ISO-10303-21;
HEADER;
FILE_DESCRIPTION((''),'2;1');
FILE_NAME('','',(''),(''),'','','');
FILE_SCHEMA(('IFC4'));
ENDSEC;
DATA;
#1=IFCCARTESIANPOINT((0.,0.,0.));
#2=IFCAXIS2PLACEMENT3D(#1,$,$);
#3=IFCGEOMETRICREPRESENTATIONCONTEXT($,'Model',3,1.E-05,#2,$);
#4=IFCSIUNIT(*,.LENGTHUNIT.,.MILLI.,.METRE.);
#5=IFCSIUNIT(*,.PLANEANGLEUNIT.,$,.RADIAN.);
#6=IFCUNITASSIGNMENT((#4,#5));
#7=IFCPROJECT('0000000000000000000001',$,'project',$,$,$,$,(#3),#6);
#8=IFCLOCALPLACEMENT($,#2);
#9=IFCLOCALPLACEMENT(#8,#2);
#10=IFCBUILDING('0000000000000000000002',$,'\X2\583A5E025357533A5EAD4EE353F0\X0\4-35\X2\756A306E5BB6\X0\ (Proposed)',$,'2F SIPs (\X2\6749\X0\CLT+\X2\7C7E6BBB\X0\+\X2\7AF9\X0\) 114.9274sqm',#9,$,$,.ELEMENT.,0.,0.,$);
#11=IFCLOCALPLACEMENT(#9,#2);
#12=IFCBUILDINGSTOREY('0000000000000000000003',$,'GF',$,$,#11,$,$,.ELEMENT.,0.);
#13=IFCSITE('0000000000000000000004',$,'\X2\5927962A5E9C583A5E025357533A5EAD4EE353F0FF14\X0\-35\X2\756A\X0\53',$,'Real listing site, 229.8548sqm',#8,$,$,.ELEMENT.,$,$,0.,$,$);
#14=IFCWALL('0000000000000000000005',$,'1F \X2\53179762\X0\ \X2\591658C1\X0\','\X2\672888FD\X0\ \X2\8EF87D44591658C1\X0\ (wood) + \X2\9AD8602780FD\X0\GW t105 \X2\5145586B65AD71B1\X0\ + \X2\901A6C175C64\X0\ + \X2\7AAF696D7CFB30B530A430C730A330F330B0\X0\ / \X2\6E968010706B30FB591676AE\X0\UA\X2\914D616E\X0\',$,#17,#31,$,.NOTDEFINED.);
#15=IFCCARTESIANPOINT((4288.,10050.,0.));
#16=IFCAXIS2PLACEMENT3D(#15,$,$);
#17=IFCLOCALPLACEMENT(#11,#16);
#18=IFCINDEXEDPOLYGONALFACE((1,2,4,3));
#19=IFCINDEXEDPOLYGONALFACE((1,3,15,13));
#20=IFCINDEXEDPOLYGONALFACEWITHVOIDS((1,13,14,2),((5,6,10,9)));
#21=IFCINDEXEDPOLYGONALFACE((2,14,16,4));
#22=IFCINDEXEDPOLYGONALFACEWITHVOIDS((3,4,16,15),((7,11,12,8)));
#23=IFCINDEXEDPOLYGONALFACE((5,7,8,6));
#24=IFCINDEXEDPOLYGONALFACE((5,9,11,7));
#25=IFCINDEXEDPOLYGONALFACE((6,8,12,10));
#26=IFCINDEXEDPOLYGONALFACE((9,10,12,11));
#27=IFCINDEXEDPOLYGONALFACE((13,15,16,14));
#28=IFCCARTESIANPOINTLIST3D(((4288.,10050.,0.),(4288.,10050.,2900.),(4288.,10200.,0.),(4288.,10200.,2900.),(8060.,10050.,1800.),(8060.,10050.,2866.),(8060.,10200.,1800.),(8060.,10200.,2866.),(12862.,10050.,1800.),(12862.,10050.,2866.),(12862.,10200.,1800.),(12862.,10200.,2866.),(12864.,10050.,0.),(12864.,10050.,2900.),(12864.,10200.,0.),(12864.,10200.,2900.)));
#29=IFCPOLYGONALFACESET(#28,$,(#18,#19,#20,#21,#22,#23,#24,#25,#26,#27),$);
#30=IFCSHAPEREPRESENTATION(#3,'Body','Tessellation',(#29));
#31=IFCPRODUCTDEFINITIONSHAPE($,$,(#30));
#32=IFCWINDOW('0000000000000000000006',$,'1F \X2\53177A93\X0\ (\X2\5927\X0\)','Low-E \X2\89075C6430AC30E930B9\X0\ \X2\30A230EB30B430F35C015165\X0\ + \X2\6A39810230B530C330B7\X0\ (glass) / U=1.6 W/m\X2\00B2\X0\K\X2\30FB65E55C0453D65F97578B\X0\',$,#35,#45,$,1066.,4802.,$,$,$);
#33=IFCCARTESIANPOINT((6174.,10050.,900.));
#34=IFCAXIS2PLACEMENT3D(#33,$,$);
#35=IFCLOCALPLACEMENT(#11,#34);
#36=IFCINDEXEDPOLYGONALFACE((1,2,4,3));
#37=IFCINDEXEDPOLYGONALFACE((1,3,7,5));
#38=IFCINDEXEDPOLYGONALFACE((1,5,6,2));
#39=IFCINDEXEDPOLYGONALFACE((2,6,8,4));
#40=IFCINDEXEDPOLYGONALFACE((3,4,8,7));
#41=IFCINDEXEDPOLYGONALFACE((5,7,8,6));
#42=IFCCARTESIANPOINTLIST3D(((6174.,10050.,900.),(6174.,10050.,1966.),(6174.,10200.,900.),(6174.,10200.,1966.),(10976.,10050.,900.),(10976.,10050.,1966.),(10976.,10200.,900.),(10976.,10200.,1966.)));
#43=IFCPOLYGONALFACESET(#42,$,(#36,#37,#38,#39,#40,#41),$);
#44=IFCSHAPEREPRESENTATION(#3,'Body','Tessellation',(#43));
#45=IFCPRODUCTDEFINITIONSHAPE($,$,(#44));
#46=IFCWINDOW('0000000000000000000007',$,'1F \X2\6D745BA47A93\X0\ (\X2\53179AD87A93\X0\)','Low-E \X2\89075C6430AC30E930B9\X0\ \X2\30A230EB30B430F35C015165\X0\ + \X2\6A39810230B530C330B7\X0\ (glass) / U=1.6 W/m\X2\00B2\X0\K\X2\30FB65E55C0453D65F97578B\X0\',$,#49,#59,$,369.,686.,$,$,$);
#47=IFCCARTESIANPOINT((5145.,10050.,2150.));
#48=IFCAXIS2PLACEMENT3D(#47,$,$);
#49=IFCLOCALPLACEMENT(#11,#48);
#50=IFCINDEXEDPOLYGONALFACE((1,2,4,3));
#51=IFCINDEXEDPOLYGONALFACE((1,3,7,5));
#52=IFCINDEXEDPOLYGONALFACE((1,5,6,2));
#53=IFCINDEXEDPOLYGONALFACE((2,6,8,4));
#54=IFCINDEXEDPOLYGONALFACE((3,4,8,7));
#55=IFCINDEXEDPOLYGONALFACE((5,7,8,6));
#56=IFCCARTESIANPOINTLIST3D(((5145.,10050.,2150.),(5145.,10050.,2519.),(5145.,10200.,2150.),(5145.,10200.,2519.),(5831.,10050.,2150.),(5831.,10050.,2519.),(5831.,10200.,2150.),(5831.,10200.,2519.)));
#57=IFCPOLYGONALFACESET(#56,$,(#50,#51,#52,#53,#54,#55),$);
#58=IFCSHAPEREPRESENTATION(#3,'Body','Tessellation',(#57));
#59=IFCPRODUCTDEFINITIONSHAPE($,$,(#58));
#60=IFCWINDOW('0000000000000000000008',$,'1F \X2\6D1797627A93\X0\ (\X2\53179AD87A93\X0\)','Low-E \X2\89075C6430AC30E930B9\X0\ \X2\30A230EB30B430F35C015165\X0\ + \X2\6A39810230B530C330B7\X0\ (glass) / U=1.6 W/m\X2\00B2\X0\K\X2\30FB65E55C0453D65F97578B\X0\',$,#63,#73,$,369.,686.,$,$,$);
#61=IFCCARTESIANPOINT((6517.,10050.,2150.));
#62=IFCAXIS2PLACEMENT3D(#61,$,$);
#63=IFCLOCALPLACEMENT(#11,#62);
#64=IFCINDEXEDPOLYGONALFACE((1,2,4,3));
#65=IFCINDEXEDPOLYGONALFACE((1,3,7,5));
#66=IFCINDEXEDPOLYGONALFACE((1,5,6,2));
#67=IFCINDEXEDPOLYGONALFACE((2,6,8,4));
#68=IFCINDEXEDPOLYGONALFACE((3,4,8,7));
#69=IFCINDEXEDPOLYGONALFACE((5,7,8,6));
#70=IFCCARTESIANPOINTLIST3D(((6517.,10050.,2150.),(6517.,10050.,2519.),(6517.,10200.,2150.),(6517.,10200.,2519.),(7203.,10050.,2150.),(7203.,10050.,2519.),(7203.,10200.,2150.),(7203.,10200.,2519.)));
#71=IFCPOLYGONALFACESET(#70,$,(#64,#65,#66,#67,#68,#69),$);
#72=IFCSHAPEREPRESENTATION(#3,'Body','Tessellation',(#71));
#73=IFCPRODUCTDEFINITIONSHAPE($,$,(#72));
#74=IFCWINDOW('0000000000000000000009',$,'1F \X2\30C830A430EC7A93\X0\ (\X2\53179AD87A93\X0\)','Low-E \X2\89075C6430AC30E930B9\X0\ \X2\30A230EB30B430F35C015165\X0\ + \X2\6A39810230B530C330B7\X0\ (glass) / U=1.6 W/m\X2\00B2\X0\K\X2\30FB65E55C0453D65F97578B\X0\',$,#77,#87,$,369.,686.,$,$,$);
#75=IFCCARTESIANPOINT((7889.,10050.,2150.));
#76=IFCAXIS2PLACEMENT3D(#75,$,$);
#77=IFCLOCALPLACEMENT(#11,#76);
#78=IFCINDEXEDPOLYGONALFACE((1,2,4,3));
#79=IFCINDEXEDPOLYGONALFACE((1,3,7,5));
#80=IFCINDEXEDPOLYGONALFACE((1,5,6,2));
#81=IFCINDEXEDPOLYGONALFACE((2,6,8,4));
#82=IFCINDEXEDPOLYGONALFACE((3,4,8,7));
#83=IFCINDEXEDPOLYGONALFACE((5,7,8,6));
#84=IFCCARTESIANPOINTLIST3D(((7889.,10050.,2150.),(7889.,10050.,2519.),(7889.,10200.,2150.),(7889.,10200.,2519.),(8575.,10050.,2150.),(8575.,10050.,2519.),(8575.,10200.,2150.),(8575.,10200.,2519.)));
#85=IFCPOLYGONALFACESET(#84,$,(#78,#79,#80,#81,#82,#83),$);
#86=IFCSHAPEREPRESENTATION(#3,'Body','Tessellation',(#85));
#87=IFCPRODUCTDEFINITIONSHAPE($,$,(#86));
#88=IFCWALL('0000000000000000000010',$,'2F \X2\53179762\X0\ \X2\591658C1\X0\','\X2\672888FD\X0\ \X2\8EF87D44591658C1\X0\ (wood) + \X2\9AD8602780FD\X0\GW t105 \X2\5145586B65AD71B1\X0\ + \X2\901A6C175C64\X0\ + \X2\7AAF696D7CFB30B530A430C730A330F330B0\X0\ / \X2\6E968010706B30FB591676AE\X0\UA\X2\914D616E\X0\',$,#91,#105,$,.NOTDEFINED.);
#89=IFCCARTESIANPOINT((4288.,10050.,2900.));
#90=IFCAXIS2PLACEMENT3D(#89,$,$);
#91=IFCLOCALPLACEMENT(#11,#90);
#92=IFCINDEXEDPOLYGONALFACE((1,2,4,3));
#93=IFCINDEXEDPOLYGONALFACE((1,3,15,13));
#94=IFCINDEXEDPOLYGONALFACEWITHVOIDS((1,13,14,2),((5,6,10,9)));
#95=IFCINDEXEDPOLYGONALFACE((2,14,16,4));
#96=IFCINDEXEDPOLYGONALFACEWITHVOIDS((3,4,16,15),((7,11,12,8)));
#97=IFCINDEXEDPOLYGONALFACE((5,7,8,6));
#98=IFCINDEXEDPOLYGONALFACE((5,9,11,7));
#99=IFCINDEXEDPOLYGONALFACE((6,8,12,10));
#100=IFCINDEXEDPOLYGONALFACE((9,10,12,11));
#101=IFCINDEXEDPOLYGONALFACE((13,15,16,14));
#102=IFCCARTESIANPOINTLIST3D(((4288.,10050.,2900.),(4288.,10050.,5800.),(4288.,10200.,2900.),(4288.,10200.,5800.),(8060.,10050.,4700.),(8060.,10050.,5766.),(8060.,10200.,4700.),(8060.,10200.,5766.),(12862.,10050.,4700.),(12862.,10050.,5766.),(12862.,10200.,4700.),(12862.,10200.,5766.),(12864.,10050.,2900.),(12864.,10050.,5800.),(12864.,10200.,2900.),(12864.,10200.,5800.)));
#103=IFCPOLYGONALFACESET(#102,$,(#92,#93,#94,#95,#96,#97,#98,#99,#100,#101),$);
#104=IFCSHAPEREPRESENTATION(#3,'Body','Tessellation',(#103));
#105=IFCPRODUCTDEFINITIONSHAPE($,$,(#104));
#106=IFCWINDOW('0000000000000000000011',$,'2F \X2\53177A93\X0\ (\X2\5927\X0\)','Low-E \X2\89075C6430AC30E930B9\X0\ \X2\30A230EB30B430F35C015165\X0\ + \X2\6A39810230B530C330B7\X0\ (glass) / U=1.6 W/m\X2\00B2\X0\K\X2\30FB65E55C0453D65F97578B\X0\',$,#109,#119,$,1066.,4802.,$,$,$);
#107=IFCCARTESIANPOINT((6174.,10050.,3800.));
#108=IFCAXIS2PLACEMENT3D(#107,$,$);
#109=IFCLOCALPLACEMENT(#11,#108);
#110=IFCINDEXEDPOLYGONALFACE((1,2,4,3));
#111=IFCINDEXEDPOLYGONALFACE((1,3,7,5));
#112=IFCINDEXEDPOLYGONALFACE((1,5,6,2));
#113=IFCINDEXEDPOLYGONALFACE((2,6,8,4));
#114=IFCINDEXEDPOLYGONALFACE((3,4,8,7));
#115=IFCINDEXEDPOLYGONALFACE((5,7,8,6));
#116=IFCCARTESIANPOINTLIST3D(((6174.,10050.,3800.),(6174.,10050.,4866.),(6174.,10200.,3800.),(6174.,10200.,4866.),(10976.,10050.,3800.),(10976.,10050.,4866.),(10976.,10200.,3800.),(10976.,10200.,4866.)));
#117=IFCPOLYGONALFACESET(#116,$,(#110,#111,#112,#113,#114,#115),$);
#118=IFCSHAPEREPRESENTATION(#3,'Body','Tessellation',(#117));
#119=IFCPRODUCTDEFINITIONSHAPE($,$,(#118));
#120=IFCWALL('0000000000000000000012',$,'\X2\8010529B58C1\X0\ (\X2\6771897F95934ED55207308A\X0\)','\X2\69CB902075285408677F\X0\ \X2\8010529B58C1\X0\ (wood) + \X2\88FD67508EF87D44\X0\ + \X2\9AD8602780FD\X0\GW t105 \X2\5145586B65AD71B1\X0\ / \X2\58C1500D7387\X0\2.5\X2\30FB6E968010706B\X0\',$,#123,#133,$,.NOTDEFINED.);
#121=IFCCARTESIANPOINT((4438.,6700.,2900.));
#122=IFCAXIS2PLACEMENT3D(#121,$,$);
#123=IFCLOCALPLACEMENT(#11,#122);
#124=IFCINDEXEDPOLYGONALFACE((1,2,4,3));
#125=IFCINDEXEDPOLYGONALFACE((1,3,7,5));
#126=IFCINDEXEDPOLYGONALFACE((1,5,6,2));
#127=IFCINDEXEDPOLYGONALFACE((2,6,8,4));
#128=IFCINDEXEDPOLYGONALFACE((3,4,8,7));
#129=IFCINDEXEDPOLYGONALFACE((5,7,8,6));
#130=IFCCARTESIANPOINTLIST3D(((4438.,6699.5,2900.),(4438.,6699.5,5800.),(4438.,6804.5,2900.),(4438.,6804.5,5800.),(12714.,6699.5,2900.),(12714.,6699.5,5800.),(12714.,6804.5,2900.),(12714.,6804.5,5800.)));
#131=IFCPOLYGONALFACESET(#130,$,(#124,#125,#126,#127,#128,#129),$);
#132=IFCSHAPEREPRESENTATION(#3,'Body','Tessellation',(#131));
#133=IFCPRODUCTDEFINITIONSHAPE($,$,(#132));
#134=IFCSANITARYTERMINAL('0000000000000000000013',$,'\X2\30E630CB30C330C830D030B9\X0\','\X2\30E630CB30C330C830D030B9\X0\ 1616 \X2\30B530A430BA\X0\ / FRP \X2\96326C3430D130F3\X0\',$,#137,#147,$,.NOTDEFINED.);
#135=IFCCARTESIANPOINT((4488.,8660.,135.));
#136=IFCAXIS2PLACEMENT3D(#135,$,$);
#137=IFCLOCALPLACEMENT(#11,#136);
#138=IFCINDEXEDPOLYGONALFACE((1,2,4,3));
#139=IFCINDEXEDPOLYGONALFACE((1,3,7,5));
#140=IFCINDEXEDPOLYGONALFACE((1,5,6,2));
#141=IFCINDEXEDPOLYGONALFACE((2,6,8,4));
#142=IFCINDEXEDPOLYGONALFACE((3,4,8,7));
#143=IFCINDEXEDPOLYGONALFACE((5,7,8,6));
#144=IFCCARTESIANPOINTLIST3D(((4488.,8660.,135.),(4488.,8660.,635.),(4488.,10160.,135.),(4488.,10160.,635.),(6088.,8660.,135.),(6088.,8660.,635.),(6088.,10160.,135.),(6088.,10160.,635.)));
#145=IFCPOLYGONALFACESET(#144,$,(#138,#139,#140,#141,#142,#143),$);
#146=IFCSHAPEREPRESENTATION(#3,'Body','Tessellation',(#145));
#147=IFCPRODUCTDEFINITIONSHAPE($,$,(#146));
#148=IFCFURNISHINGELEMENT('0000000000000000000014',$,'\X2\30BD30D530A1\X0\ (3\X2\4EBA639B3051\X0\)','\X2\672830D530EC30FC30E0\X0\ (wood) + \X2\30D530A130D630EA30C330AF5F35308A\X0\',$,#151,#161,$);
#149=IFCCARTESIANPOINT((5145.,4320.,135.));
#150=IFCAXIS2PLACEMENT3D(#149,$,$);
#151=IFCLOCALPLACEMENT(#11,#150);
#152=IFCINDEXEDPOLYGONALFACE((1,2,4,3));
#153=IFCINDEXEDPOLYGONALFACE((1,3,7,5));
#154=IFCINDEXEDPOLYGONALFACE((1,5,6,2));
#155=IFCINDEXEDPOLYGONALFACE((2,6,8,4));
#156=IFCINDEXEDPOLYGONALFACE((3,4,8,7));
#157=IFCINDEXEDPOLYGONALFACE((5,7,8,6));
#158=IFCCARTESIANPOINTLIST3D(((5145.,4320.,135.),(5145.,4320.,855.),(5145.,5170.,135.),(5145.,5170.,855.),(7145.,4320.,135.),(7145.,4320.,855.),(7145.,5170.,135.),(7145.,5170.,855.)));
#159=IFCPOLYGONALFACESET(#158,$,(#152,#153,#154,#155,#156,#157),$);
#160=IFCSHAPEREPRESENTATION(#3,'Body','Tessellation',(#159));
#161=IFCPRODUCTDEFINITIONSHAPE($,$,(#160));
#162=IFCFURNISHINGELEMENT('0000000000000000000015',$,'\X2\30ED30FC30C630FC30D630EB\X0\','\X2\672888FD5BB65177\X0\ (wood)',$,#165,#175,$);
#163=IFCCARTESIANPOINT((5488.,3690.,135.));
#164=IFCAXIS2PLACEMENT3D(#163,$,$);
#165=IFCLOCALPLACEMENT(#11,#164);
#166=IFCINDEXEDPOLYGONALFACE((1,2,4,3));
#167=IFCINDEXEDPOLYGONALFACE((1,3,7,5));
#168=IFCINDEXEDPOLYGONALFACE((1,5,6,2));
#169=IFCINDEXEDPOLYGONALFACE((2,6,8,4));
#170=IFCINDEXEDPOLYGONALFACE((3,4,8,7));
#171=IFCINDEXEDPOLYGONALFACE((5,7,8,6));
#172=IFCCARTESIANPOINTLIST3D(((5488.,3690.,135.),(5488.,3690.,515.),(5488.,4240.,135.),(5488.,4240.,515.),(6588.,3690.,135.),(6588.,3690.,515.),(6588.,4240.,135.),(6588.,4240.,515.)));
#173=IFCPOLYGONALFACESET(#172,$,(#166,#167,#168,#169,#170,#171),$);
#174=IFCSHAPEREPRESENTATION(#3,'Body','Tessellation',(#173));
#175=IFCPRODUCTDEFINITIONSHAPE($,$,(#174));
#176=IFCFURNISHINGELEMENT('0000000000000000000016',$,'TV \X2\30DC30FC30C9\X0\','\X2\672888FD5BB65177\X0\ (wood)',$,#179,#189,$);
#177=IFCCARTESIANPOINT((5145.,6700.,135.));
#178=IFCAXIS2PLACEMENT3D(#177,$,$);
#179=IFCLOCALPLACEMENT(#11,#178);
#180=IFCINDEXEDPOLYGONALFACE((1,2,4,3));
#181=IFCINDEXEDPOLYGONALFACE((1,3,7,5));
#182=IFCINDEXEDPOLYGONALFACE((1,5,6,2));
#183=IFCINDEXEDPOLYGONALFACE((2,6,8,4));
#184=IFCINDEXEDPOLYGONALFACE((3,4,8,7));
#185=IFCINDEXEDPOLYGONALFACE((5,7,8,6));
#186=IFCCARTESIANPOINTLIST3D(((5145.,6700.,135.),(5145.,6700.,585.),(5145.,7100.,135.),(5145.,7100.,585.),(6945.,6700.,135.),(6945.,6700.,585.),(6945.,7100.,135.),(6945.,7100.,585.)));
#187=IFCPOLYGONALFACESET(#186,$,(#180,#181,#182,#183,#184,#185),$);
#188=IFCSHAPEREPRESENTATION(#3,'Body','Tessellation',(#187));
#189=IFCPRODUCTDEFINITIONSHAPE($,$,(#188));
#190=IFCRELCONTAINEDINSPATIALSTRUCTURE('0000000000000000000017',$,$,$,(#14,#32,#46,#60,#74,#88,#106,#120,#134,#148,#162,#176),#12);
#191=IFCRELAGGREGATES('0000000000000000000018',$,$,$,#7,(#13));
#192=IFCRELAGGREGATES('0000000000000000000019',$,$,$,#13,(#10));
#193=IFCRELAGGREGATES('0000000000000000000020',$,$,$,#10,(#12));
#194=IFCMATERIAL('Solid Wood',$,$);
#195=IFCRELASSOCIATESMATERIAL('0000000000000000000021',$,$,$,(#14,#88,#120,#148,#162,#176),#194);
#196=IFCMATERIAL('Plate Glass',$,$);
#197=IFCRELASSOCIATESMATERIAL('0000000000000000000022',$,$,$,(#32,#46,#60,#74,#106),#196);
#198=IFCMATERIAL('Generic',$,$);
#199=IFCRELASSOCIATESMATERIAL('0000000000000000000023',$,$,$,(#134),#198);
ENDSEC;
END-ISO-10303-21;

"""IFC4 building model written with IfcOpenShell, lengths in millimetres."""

from ifc_helpers import new_model, si_unit, frame, frame_2d, origin, place, context, project, spatial, rectangle, extrude, material, element, fill, save


model = new_model("IFC4")

# Units and contexts
model_context = context("Model", 3, precision=1e-05, world=origin())
ifc_project = project(units=[si_unit("LENGTHUNIT", "METRE", prefix="MILLI"), si_unit("PLANEANGLEUNIT", "RADIAN")], contexts=[model_context])

# Site, building, storey
site_placement = place(None, origin())
site = spatial("IfcSite", under=ifc_project, at=site_placement, Name="大阪府堺市南区庭代台４-35番53", ObjectType="Real listing site, 229.8548sqm", CompositionType="ELEMENT", RefElevation=0.0)
building_placement = place(site_placement, origin())
building = spatial("IfcBuilding", under=site, at=building_placement, Name="堺市南区庭代台4-35番の家 (Proposed)", ObjectType="2F SIPs (杉CLT+籾殻+竹) 114.9274sqm", CompositionType="ELEMENT", ElevationOfRefHeight=0.0, ElevationOfTerrain=0.0)
storey_placement = place(building_placement, origin())
storey = spatial("IfcBuildingStorey", under=building, at=storey_placement, Name="GF", CompositionType="ELEMENT", Elevation=0.0)

# Wall, openings, windows
ifc_material_1 = material(Name="Solid Wood")
wall_1_placement = place(storey_placement, frame((4288.0, 10050.0, 0.0)))
wall_1 = element("IfcWall", 1, at=wall_1_placement, inside=storey, material=ifc_material_1, Name="1F 北面 外壁", Description="木製 軸組外壁 (wood) + 高性能GW t105 充填断熱 + 通気層 + 窯業系サイディング / 準耐火・外皮UA配慮", PredefinedType="NOTDEFINED", context=model_context, shape_type="SweptSolid", body=[
    extrude(rectangle(XDim=8576.0, YDim=150.0, at=frame_2d((4288.0, 75.0))), frame((4288.0, 10050.0, 0.0)), (0.0, 0.0, 1.0), 2900.0),
])
opening_1_placement = place(storey_placement, frame((6174.0, 10050.0, 900.0)))
opening_1 = element("IfcOpeningElement", 2, at=opening_1_placement, cuts=wall_1, PredefinedType="NOTDEFINED", context=model_context, shape_type="SweptSolid", body=[
    extrude(rectangle(XDim=4802.0, YDim=150.0, at=frame_2d((2401.0, 75.0))), frame((6174.0, 10050.0, 900.0)), (0.0, 0.0, 1.0), 1066.0),
])
opening_2_placement = place(storey_placement, frame((5145.0, 10050.0, 2150.0)))
opening_2 = element("IfcOpeningElement", 3, at=opening_2_placement, cuts=wall_1, PredefinedType="NOTDEFINED", context=model_context, shape_type="SweptSolid", body=[
    extrude(rectangle(XDim=686.0, YDim=150.0, at=frame_2d((343.0, 75.0))), frame((5145.0, 10050.0, 2150.0)), (0.0, 0.0, 1.0), 369.0),
])
opening_3_placement = place(storey_placement, frame((6517.0, 10050.0, 2150.0)))
opening_3 = element("IfcOpeningElement", 4, at=opening_3_placement, cuts=wall_1, PredefinedType="NOTDEFINED", context=model_context, shape_type="SweptSolid", body=[
    extrude(rectangle(XDim=686.0, YDim=150.0, at=frame_2d((343.0, 75.0))), frame((6517.0, 10050.0, 2150.0)), (0.0, 0.0, 1.0), 369.0),
])
opening_4_placement = place(storey_placement, frame((7889.0, 10050.0, 2150.0)))
opening_4 = element("IfcOpeningElement", 5, at=opening_4_placement, cuts=wall_1, PredefinedType="NOTDEFINED", context=model_context, shape_type="SweptSolid", body=[
    extrude(rectangle(XDim=686.0, YDim=150.0, at=frame_2d((343.0, 75.0))), frame((7889.0, 10050.0, 2150.0)), (0.0, 0.0, 1.0), 369.0),
])
ifc_material_2 = material(Name="Plate Glass")
window_1_placement = place(storey_placement, frame((6174.0, 10050.0, 900.0)))
window_1 = element("IfcWindow", 6, at=window_1_placement, inside=storey, material=ifc_material_2, Name="1F 北窓 (大)", Description="Low-E 複層ガラス アルゴン封入 + 樹脂サッシ (glass) / U=1.6 W/m²K・日射取得型", OverallHeight=1066.0, OverallWidth=4802.0, context=model_context, shape_type="SweptSolid", body=[
    extrude(rectangle(XDim=4802.0, YDim=150.0, at=frame_2d((2401.0, 75.0))), frame((6174.0, 10050.0, 900.0)), (0.0, 0.0, 1.0), 1066.0),
])
fill(opening_1, window_1)
window_2_placement = place(storey_placement, frame((5145.0, 10050.0, 2150.0)))
window_2 = element("IfcWindow", 7, at=window_2_placement, inside=storey, material=ifc_material_2, Name="1F 浴室窓 (北高窓)", Description="Low-E 複層ガラス アルゴン封入 + 樹脂サッシ (glass) / U=1.6 W/m²K・日射取得型", OverallHeight=369.0, OverallWidth=686.0, context=model_context, shape_type="SweptSolid", body=[
    extrude(rectangle(XDim=686.0, YDim=150.0, at=frame_2d((343.0, 75.0))), frame((5145.0, 10050.0, 2150.0)), (0.0, 0.0, 1.0), 369.0),
])
fill(opening_2, window_2)
window_3_placement = place(storey_placement, frame((6517.0, 10050.0, 2150.0)))
window_3 = element("IfcWindow", 8, at=window_3_placement, inside=storey, material=ifc_material_2, Name="1F 洗面窓 (北高窓)", Description="Low-E 複層ガラス アルゴン封入 + 樹脂サッシ (glass) / U=1.6 W/m²K・日射取得型", OverallHeight=369.0, OverallWidth=686.0, context=model_context, shape_type="SweptSolid", body=[
    extrude(rectangle(XDim=686.0, YDim=150.0, at=frame_2d((343.0, 75.0))), frame((6517.0, 10050.0, 2150.0)), (0.0, 0.0, 1.0), 369.0),
])
fill(opening_3, window_3)
window_4_placement = place(storey_placement, frame((7889.0, 10050.0, 2150.0)))
window_4 = element("IfcWindow", 9, at=window_4_placement, inside=storey, material=ifc_material_2, Name="1F トイレ窓 (北高窓)", Description="Low-E 複層ガラス アルゴン封入 + 樹脂サッシ (glass) / U=1.6 W/m²K・日射取得型", OverallHeight=369.0, OverallWidth=686.0, context=model_context, shape_type="SweptSolid", body=[
    extrude(rectangle(XDim=686.0, YDim=150.0, at=frame_2d((343.0, 75.0))), frame((7889.0, 10050.0, 2150.0)), (0.0, 0.0, 1.0), 369.0),
])
fill(opening_4, window_4)

# Wall, opening, window
wall_2_placement = place(storey_placement, frame((4288.0, 10050.0, 2900.0)))
wall_2 = element("IfcWall", 10, at=wall_2_placement, inside=storey, material=ifc_material_1, Name="2F 北面 外壁", Description="木製 軸組外壁 (wood) + 高性能GW t105 充填断熱 + 通気層 + 窯業系サイディング / 準耐火・外皮UA配慮", PredefinedType="NOTDEFINED", context=model_context, shape_type="SweptSolid", body=[
    extrude(rectangle(XDim=8576.0, YDim=150.0, at=frame_2d((4288.0, 75.0))), frame((4288.0, 10050.0, 2900.0)), (0.0, 0.0, 1.0), 2900.0),
])
opening_5_placement = place(storey_placement, frame((6174.0, 10050.0, 3800.0)))
opening_5 = element("IfcOpeningElement", 11, at=opening_5_placement, cuts=wall_2, PredefinedType="NOTDEFINED", context=model_context, shape_type="SweptSolid", body=[
    extrude(rectangle(XDim=4802.0, YDim=150.0, at=frame_2d((2401.0, 75.0))), frame((6174.0, 10050.0, 3800.0)), (0.0, 0.0, 1.0), 1066.0),
])
window_5_placement = place(storey_placement, frame((6174.0, 10050.0, 3800.0)))
window_5 = element("IfcWindow", 12, at=window_5_placement, inside=storey, material=ifc_material_2, Name="2F 北窓 (大)", Description="Low-E 複層ガラス アルゴン封入 + 樹脂サッシ (glass) / U=1.6 W/m²K・日射取得型", OverallHeight=1066.0, OverallWidth=4802.0, context=model_context, shape_type="SweptSolid", body=[
    extrude(rectangle(XDim=4802.0, YDim=150.0, at=frame_2d((2401.0, 75.0))), frame((6174.0, 10050.0, 3800.0)), (0.0, 0.0, 1.0), 1066.0),
])
fill(opening_5, window_5)

# Wall
wall_3_placement = place(storey_placement, frame((4438.0, 6700.0, 2900.0)))
element("IfcWall", 13, at=wall_3_placement, inside=storey, material=ifc_material_1, Name="耐力壁 (東西間仕切り)", Description="構造用合板 耐力壁 (wood) + 製材軸組 + 高性能GW t105 充填断熱 / 壁倍率2.5・準耐火", PredefinedType="NOTDEFINED", context=model_context, shape_type="SweptSolid", body=[
    extrude(rectangle(XDim=8276.0, YDim=105.0, at=frame_2d((4138.0, 52.0))), frame((4438.0, 6700.0, 2900.0)), (0.0, 0.0, 1.0), 2900.0),
])

# Sanitary terminal
ifc_material_3 = material(Name="Generic")
sanitary_terminal_placement = place(storey_placement, frame((4488.0, 8660.0, 135.0)))
element("IfcSanitaryTerminal", 14, at=sanitary_terminal_placement, inside=storey, material=ifc_material_3, Name="ユニットバス", Description="ユニットバス 1616 サイズ / FRP 防水パン", PredefinedType="NOTDEFINED", context=model_context, shape_type="SweptSolid", body=[
    extrude(rectangle(XDim=1600.0, YDim=1500.0, at=frame_2d((800.0, 750.0))), frame((4488.0, 8660.0, 135.0)), (0.0, 0.0, 1.0), 500.0),
])

# Furnishing elements
furnishing_1_placement = place(storey_placement, frame((5145.0, 4320.0, 135.0)))
element("IfcFurnishingElement", 15, at=furnishing_1_placement, inside=storey, material=ifc_material_1, Name="ソファ (3人掛け)", Description="木フレーム (wood) + ファブリック張り", context=model_context, shape_type="SweptSolid", body=[
    extrude(rectangle(XDim=2000.0, YDim=850.0, at=frame_2d((1000.0, 425.0))), frame((5145.0, 4320.0, 135.0)), (0.0, 0.0, 1.0), 720.0),
])
furnishing_2_placement = place(storey_placement, frame((5488.0, 3690.0, 135.0)))
element("IfcFurnishingElement", 16, at=furnishing_2_placement, inside=storey, material=ifc_material_1, Name="ローテーブル", Description="木製家具 (wood)", context=model_context, shape_type="SweptSolid", body=[
    extrude(rectangle(XDim=1100.0, YDim=550.0, at=frame_2d((550.0, 275.0))), frame((5488.0, 3690.0, 135.0)), (0.0, 0.0, 1.0), 380.0),
])
furnishing_3_placement = place(storey_placement, frame((5145.0, 6700.0, 135.0)))
element("IfcFurnishingElement", 17, at=furnishing_3_placement, inside=storey, material=ifc_material_1, Name="TV ボード", Description="木製家具 (wood)", context=model_context, shape_type="SweptSolid", body=[
    extrude(rectangle(XDim=1800.0, YDim=400.0, at=frame_2d((900.0, 200.0))), frame((5145.0, 6700.0, 135.0)), (0.0, 0.0, 1.0), 450.0),
])

save(model, "model.ifc")
